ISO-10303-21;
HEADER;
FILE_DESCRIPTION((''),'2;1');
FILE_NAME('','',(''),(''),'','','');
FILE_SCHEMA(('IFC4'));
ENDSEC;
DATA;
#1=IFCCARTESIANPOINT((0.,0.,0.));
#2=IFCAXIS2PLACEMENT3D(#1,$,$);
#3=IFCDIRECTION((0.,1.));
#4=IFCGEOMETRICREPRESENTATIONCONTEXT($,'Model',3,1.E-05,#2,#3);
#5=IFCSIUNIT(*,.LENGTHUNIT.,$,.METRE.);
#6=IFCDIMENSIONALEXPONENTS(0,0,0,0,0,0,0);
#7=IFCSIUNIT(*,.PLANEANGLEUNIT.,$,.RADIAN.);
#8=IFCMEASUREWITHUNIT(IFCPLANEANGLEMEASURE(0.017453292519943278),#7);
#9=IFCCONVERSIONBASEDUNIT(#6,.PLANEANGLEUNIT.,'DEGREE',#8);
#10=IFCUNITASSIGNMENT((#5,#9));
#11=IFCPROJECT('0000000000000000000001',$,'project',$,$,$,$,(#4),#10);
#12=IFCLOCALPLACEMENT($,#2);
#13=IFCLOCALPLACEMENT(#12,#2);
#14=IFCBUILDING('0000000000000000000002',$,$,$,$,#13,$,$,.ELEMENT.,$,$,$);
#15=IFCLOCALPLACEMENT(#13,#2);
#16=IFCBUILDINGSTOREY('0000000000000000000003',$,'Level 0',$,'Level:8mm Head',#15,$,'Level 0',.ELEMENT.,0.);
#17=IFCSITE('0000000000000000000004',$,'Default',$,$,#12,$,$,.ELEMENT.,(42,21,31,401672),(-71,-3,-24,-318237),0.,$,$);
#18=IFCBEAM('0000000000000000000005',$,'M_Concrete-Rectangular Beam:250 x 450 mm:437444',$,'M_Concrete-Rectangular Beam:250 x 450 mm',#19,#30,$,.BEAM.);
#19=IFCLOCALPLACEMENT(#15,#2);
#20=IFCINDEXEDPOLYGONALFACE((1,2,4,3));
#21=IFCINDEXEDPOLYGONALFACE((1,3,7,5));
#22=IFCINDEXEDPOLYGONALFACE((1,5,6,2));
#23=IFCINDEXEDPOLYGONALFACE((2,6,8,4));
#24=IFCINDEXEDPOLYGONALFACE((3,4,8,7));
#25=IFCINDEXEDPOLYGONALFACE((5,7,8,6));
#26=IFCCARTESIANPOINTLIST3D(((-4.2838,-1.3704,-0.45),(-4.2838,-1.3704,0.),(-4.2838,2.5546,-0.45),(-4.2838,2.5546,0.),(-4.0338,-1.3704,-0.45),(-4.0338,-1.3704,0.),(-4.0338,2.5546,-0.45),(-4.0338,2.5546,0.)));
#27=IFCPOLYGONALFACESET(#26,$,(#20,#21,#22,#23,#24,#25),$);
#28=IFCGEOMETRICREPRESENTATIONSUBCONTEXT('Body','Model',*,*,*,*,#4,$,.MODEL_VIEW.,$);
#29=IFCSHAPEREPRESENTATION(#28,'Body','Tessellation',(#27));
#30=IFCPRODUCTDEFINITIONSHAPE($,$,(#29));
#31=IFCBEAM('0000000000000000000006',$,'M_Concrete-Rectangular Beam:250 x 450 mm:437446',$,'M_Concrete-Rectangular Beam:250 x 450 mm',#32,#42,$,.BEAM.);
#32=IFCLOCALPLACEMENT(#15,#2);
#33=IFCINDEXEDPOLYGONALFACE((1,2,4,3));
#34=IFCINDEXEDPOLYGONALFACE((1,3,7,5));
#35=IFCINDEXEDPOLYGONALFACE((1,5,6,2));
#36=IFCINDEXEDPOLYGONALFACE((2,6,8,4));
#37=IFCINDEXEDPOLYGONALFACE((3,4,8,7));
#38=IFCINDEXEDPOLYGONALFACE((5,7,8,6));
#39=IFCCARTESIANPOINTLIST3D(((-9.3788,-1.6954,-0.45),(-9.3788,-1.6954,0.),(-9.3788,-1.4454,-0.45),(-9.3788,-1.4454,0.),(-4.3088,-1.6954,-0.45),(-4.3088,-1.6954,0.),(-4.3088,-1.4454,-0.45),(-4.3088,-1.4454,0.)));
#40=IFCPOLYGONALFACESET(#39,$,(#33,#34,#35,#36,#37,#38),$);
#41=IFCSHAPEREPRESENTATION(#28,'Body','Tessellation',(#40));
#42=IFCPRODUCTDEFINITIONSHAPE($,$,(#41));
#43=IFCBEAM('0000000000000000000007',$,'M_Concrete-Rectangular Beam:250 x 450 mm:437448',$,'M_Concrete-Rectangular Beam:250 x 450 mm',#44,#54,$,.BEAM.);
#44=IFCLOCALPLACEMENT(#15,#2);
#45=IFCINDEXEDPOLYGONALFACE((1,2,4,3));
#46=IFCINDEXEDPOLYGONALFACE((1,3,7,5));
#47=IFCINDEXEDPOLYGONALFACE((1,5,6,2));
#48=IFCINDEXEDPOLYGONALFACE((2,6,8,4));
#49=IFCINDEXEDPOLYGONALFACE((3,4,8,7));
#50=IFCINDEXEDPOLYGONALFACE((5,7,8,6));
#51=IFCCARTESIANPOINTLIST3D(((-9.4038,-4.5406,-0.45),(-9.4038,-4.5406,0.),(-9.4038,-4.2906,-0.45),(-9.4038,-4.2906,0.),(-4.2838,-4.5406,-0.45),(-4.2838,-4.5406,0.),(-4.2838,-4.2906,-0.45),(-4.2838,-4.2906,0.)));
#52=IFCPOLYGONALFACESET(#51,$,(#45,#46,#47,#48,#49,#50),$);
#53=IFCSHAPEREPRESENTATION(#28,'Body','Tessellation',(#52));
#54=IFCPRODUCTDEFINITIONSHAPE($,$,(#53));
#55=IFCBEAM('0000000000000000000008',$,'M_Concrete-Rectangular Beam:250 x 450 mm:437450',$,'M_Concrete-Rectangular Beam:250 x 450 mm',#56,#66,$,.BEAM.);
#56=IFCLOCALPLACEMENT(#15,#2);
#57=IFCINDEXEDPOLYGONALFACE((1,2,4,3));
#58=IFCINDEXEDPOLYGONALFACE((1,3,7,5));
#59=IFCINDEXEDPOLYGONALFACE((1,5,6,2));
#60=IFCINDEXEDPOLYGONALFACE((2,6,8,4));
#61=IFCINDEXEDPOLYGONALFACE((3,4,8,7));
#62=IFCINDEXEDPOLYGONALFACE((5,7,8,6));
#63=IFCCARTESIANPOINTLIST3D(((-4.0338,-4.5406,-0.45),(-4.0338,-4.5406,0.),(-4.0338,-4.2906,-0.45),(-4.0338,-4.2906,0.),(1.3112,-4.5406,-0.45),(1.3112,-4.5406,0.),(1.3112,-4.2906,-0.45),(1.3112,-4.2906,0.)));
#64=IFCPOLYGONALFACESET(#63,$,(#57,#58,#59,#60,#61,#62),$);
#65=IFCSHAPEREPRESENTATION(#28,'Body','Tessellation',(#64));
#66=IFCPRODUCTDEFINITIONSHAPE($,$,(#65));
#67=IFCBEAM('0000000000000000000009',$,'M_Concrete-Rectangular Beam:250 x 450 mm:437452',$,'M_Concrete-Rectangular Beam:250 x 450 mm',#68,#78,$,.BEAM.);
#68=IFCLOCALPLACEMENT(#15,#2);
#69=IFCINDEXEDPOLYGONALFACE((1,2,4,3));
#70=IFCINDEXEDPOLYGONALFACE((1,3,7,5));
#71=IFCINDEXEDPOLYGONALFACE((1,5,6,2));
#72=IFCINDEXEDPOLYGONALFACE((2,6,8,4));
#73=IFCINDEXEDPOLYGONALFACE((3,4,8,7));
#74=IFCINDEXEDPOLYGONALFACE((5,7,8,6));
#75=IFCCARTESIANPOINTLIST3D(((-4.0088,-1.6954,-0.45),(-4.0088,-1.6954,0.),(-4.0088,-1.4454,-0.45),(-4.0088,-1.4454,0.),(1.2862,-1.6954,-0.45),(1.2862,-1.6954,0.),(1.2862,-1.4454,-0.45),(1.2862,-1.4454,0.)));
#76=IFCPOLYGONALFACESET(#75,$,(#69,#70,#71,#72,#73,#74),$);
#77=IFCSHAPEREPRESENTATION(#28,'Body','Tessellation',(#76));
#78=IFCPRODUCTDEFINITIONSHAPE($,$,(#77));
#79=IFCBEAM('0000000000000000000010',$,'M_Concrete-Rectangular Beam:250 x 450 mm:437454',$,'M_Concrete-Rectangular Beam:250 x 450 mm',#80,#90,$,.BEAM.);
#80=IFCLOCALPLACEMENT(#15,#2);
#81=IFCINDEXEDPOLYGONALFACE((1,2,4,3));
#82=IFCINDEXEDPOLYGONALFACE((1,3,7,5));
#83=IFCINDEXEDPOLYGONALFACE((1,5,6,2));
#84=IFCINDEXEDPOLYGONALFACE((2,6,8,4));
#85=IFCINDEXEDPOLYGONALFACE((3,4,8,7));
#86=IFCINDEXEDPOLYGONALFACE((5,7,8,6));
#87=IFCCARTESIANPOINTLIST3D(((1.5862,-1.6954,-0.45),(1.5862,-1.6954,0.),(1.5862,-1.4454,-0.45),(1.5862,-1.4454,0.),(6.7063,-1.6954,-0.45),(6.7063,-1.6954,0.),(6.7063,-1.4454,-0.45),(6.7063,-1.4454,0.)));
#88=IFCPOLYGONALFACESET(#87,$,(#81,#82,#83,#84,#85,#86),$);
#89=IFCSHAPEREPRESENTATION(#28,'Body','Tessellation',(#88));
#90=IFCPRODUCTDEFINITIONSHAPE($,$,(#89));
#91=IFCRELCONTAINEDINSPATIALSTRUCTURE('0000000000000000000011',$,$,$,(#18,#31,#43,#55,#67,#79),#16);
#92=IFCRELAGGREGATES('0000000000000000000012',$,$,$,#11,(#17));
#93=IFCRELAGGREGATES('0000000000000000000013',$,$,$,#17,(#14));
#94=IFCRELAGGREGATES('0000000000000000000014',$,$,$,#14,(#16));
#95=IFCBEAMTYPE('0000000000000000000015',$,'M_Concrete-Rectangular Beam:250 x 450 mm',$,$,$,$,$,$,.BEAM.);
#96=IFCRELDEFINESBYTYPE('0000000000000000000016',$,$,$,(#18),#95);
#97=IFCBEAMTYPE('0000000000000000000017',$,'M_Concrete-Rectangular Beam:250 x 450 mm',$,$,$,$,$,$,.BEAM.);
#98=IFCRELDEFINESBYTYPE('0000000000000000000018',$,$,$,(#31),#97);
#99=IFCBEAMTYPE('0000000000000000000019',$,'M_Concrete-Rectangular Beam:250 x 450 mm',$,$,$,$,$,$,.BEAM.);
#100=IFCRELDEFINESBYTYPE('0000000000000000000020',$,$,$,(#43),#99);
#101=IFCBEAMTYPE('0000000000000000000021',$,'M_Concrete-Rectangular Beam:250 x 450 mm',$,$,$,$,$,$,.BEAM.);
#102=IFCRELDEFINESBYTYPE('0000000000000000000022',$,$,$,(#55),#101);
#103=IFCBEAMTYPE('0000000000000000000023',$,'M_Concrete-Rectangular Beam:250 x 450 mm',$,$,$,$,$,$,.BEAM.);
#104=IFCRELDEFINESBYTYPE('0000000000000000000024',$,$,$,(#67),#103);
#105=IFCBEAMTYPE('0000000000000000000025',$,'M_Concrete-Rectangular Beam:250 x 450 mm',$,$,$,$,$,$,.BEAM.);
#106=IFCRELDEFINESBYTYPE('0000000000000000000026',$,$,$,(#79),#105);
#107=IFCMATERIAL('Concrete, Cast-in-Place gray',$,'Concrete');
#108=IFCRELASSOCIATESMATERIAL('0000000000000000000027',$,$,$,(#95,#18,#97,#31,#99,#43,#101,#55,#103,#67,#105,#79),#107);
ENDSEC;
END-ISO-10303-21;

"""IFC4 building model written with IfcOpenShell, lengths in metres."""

from ifc_helpers import new_model, entity, si_unit, converted_unit, direction, frame, origin, place, context, subcontext, project, spatial, indexed_curve, outline, extrude, source, transform, mapped, material, type_object, type_shapes, element, save


model = new_model("IFC4")

# Units and contexts
model_context = context("Model", 3, precision=1e-05, world=origin(), true_north=direction((0.0, 1.0)))
body_context = subcontext(model_context, "Body", "Model", "MODEL_VIEW")
ifc_project = project(units=[si_unit("LENGTHUNIT", "METRE"), converted_unit("PLANEANGLEUNIT", "DEGREE", entity("IfcPlaneAngleMeasure", 0.017453292519943278), si_unit("PLANEANGLEUNIT", "RADIAN"), dimensions=[0, 0, 0, 0, 0, 0, 0])], contexts=[model_context])

# Site, building, storey
site_placement = place(None, origin())
site = spatial("IfcSite", under=ifc_project, at=site_placement, Name="Default", CompositionType="ELEMENT", RefLatitude=(42, 21, 31, 401672), RefLongitude=(-71, -3, -24, -318237), RefElevation=0.0)
building_placement = place(site_placement, origin())
building = spatial("IfcBuilding", under=site, at=building_placement, CompositionType="ELEMENT")
storey_placement = place(building_placement, origin())
storey = spatial("IfcBuildingStorey", under=building, at=storey_placement, Name="Level 0", ObjectType="Level:8mm Head", LongName="Level 0", CompositionType="ELEMENT", Elevation=0.0)

# Beams
ifc_material = material(Name="Concrete, Cast-in-Place gray", Category="Concrete")
beam_type_1 = type_object("IfcBeamType", Name="M_Concrete-Rectangular Beam:250 x 450 mm", PredefinedType="BEAM", material=ifc_material)
shared_shape_1 = source(origin(), body_context, "Body", "SweptSolid", [
    extrude(outline(indexed_curve([(-0.125, -0.225), (0.125, -0.225), (0.125, 0.225), (-0.125, 0.225), (-0.125, -0.225)], self_intersect=False)), frame((-4.1588, 2.5546, -0.225), z_axis=(0.0, -1.0, 0.0), x_axis=(-1.0, 0.0, 0.0)), (0.0, 0.0, 1.0), 3.925),
])
type_shapes(beam_type_1, [shared_shape_1])
beam_1_placement = place(storey_placement, origin())
element("IfcBeam", 1, at=beam_1_placement, inside=storey, type_object=beam_type_1, material=ifc_material, Name="M_Concrete-Rectangular Beam:250 x 450 mm:437444", ObjectType="M_Concrete-Rectangular Beam:250 x 450 mm", PredefinedType="BEAM", context=body_context, shape_type="MappedRepresentation", body=[
    mapped(shared_shape_1, transform((0.0, 0.0, 0.0), scale=1.0)),
])
beam_type_2 = type_object("IfcBeamType", Name="M_Concrete-Rectangular Beam:250 x 450 mm", PredefinedType="BEAM", material=ifc_material)
shared_shape_2 = source(origin(), body_context, "Body", "SweptSolid", [
    extrude(outline(indexed_curve([(-0.225, -0.125), (0.225, -0.125), (0.225, 0.125), (-0.225, 0.125), (-0.225, -0.125)], self_intersect=False)), frame((-9.3788, -1.5704, -0.225), z_axis=(1.0, 0.0, 0.0), x_axis=(0.0, 0.0, -1.0)), (0.0, 0.0, 1.0), 5.07),
])
type_shapes(beam_type_2, [shared_shape_2])
beam_2_placement = place(storey_placement, origin())
element("IfcBeam", 2, at=beam_2_placement, inside=storey, type_object=beam_type_2, material=ifc_material, Name="M_Concrete-Rectangular Beam:250 x 450 mm:437446", ObjectType="M_Concrete-Rectangular Beam:250 x 450 mm", PredefinedType="BEAM", context=body_context, shape_type="MappedRepresentation", body=[
    mapped(shared_shape_2, transform((0.0, 0.0, 0.0), scale=1.0)),
])
beam_type_3 = type_object("IfcBeamType", Name="M_Concrete-Rectangular Beam:250 x 450 mm", PredefinedType="BEAM", material=ifc_material)
shared_shape_3 = source(origin(), body_context, "Body", "SweptSolid", [
    extrude(outline(indexed_curve([(-0.225, -0.125), (0.225, -0.125), (0.225, 0.125), (-0.225, 0.125), (-0.225, -0.125)], self_intersect=False)), frame((-9.4038, -4.4156, -0.225), z_axis=(1.0, 0.0, 0.0), x_axis=(0.0, 0.0, -1.0)), (0.0, 0.0, 1.0), 5.12),
])
type_shapes(beam_type_3, [shared_shape_3])
beam_3_placement = place(storey_placement, origin())
element("IfcBeam", 3, at=beam_3_placement, inside=storey, type_object=beam_type_3, material=ifc_material, Name="M_Concrete-Rectangular Beam:250 x 450 mm:437448", ObjectType="M_Concrete-Rectangular Beam:250 x 450 mm", PredefinedType="BEAM", context=body_context, shape_type="MappedRepresentation", body=[
    mapped(shared_shape_3, transform((0.0, 0.0, 0.0), scale=1.0)),
])
beam_type_4 = type_object("IfcBeamType", Name="M_Concrete-Rectangular Beam:250 x 450 mm", PredefinedType="BEAM", material=ifc_material)
shared_shape_4 = source(origin(), body_context, "Body", "SweptSolid", [
    extrude(outline(indexed_curve([(-0.225, -0.125), (0.225, -0.125), (0.225, 0.125), (-0.225, 0.125), (-0.225, -0.125)], self_intersect=False)), frame((-4.0338, -4.4156, -0.225), z_axis=(1.0, 0.0, 0.0), x_axis=(0.0, 0.0, -1.0)), (0.0, 0.0, 1.0), 5.345),
])
type_shapes(beam_type_4, [shared_shape_4])
beam_4_placement = place(storey_placement, origin())
element("IfcBeam", 4, at=beam_4_placement, inside=storey, type_object=beam_type_4, material=ifc_material, Name="M_Concrete-Rectangular Beam:250 x 450 mm:437450", ObjectType="M_Concrete-Rectangular Beam:250 x 450 mm", PredefinedType="BEAM", context=body_context, shape_type="MappedRepresentation", body=[
    mapped(shared_shape_4, transform((0.0, 0.0, 0.0), scale=1.0)),
])
beam_type_5 = type_object("IfcBeamType", Name="M_Concrete-Rectangular Beam:250 x 450 mm", PredefinedType="BEAM", material=ifc_material)
shared_shape_5 = source(origin(), body_context, "Body", "SweptSolid", [
    extrude(outline(indexed_curve([(-0.225, -0.125), (0.225, -0.125), (0.225, 0.125), (-0.225, 0.125), (-0.225, -0.125)], self_intersect=False)), frame((-4.0088, -1.5704, -0.225), z_axis=(1.0, 0.0, 0.0), x_axis=(0.0, 0.0, -1.0)), (0.0, 0.0, 1.0), 5.295),
])
type_shapes(beam_type_5, [shared_shape_5])
beam_5_placement = place(storey_placement, origin())
element("IfcBeam", 5, at=beam_5_placement, inside=storey, type_object=beam_type_5, material=ifc_material, Name="M_Concrete-Rectangular Beam:250 x 450 mm:437452", ObjectType="M_Concrete-Rectangular Beam:250 x 450 mm", PredefinedType="BEAM", context=body_context, shape_type="MappedRepresentation", body=[
    mapped(shared_shape_5, transform((0.0, 0.0, 0.0), scale=1.0)),
])
beam_type_6 = type_object("IfcBeamType", Name="M_Concrete-Rectangular Beam:250 x 450 mm", PredefinedType="BEAM", material=ifc_material)
shared_shape_6 = source(origin(), body_context, "Body", "SweptSolid", [
    extrude(outline(indexed_curve([(-0.225, -0.125), (0.225, -0.125), (0.225, 0.125), (-0.225, 0.125), (-0.225, -0.125)], self_intersect=False)), frame((1.5862, -1.5704, -0.225), z_axis=(1.0, 0.0, 0.0), x_axis=(0.0, 0.0, -1.0)), (0.0, 0.0, 1.0), 5.1201),
])
type_shapes(beam_type_6, [shared_shape_6])
beam_6_placement = place(storey_placement, origin())
element("IfcBeam", 6, at=beam_6_placement, inside=storey, type_object=beam_type_6, material=ifc_material, Name="M_Concrete-Rectangular Beam:250 x 450 mm:437454", ObjectType="M_Concrete-Rectangular Beam:250 x 450 mm", PredefinedType="BEAM", context=body_context, shape_type="MappedRepresentation", body=[
    mapped(shared_shape_6, transform((0.0, 0.0, 0.0), scale=1.0)),
])

save(model, "model.ifc")
